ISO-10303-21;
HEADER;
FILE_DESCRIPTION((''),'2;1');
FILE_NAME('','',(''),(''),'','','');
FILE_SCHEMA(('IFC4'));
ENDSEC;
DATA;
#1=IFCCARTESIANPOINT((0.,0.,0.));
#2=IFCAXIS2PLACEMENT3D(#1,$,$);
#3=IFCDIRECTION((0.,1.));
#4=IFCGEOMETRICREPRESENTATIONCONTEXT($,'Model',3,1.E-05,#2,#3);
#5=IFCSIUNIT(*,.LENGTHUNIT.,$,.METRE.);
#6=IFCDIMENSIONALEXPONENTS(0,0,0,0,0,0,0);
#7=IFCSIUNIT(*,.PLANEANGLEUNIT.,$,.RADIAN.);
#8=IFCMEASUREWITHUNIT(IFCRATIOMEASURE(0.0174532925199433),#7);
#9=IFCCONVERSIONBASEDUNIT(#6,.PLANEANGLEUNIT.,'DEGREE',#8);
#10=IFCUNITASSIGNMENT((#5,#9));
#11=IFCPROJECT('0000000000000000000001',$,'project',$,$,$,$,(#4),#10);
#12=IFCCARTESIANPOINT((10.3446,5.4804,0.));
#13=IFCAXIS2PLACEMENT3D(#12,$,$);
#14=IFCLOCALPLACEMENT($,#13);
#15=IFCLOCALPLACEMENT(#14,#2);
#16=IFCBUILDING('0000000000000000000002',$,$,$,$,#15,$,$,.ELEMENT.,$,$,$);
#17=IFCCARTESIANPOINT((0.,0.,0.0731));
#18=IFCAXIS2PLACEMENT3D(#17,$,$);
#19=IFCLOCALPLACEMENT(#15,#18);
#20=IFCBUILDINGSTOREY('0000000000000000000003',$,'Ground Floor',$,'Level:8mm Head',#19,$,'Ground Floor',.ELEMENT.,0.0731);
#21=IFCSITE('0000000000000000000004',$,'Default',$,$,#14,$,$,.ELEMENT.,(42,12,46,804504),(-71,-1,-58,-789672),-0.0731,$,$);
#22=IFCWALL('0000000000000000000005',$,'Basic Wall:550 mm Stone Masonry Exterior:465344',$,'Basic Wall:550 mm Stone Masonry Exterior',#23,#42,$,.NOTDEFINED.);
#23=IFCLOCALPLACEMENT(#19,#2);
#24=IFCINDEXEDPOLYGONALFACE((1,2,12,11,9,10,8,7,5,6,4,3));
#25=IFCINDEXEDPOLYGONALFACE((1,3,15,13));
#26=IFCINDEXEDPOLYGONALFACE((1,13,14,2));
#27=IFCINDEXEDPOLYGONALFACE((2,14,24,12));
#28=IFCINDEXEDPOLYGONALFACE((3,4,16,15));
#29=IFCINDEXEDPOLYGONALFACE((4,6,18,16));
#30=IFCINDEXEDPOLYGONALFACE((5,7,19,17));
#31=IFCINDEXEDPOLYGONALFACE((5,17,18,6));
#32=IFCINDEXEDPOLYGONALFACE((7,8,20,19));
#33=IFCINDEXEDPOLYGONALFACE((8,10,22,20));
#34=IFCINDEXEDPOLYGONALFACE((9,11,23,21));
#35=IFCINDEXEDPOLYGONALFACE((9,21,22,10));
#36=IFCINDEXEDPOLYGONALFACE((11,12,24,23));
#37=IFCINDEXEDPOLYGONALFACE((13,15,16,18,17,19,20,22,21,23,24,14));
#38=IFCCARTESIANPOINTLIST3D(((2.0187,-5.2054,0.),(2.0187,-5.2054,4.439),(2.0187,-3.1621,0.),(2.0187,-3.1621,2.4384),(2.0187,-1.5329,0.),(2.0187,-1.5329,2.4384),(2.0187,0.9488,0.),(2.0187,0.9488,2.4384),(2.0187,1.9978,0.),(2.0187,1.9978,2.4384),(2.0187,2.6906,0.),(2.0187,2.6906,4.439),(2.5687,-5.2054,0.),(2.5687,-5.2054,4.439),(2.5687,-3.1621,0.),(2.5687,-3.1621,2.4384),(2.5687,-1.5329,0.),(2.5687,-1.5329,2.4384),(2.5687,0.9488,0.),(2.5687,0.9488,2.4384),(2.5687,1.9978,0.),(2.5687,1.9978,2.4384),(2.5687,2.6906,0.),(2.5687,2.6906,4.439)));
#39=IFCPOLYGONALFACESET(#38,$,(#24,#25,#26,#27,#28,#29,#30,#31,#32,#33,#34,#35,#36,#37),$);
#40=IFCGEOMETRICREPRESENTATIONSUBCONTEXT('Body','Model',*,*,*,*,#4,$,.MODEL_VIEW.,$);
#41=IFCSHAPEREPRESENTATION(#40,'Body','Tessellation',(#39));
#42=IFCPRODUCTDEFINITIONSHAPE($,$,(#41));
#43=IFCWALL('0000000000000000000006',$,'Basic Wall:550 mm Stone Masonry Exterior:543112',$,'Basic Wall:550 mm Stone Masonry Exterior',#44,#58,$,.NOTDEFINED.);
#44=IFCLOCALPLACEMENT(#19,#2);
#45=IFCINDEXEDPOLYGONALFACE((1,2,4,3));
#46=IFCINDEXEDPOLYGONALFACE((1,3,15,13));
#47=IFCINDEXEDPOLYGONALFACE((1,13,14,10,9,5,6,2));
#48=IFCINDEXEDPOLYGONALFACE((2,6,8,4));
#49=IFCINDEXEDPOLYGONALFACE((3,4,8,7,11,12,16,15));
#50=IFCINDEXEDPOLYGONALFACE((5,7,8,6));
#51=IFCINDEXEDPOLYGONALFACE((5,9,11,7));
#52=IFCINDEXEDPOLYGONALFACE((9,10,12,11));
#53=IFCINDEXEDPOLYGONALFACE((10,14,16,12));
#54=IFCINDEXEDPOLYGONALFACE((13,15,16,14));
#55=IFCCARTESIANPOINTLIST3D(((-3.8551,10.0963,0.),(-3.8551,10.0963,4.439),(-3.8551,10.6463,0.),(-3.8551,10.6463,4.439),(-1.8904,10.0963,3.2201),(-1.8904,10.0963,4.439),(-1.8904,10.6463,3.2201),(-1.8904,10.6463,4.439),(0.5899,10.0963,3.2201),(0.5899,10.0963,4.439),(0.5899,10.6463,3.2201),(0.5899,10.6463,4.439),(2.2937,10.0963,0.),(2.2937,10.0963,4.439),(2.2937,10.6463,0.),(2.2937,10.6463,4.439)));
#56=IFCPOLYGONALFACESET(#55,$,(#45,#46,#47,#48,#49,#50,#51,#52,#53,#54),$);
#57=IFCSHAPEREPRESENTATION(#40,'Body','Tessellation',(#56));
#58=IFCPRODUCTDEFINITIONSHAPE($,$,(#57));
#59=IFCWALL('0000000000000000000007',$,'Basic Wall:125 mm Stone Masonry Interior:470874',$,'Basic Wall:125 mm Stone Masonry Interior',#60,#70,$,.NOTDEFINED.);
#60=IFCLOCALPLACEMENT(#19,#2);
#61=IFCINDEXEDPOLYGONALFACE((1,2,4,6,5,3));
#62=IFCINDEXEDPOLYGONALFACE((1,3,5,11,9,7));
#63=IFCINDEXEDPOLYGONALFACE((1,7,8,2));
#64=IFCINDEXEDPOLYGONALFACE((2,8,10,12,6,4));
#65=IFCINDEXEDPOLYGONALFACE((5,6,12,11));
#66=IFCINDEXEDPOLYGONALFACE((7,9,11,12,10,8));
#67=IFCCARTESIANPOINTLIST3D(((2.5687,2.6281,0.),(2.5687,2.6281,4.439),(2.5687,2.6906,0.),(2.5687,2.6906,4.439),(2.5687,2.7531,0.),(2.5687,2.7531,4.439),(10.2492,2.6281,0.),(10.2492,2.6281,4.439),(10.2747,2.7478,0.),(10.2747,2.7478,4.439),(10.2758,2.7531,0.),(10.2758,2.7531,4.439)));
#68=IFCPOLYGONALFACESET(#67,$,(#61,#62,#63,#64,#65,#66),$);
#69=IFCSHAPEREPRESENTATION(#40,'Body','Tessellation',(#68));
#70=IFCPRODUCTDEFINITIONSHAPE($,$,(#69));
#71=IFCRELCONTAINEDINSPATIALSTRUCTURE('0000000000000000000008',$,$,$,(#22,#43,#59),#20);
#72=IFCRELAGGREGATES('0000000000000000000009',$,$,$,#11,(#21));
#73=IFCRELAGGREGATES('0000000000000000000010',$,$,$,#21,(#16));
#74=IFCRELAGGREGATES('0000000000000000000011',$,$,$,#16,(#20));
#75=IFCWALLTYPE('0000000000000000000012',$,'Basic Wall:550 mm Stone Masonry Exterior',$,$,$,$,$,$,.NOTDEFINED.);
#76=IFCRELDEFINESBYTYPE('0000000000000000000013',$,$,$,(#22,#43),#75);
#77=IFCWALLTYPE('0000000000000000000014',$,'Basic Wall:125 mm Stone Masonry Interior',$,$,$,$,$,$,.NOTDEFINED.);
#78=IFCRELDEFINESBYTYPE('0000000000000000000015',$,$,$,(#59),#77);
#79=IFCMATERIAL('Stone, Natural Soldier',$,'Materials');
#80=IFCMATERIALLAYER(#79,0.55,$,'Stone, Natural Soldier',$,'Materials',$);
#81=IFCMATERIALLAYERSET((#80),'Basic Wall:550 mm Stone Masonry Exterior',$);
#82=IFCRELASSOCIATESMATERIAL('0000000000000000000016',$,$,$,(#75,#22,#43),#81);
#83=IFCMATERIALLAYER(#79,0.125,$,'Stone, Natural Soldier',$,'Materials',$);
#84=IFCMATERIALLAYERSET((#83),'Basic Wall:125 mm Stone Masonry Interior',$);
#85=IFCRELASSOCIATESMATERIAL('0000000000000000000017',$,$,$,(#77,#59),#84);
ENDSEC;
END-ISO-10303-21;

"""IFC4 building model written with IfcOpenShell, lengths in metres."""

from ifc_helpers import new_model, entity, si_unit, converted_unit, direction, frame, frame_2d, origin, origin_2d_with_axis, place, context, subcontext, project, spatial, polyline, rectangle, outline, extrude, material, layer, layer_set, layer_usage, type_object, element, save


model = new_model("IFC4")

# Units and contexts
model_context = context("Model", 3, precision=1e-05, world=origin(), true_north=direction((0.0, 1.0)))
body_context = subcontext(model_context, "Body", "Model", "MODEL_VIEW")
ifc_project = project(units=[si_unit("LENGTHUNIT", "METRE"), converted_unit("PLANEANGLEUNIT", "DEGREE", entity("IfcRatioMeasure", 0.0174532925199433), si_unit("PLANEANGLEUNIT", "RADIAN"), dimensions=[0, 0, 0, 0, 0, 0, 0])], contexts=[model_context])

# Site, building, storey
site_placement = place(None, frame((10.3446, 5.4804, 0.0)))
site = spatial("IfcSite", under=ifc_project, at=site_placement, Name="Default", CompositionType="ELEMENT", RefLatitude=(42, 12, 46, 804504), RefLongitude=(-71, -1, -58, -789672), RefElevation=-0.0731)
building_placement = place(site_placement, origin())
building = spatial("IfcBuilding", under=site, at=building_placement, CompositionType="ELEMENT")
storey_placement = place(building_placement, frame((0.0, 0.0, 0.0731)))
storey = spatial("IfcBuildingStorey", under=building, at=storey_placement, Name="Ground Floor", ObjectType="Level:8mm Head", LongName="Ground Floor", CompositionType="ELEMENT", Elevation=0.0731)

# Shared definitions
ifc_material_1 = material(Name="Stone, Natural Soldier", Category="Materials")
ifc_layer_1 = layer(ifc_material_1, 0.55, Name="Stone, Natural Soldier", Category="Materials")
ifc_layer_set_1 = layer_set([ifc_layer_1], Name="Basic Wall:550 mm Stone Masonry Exterior")
wall_type_1 = type_object("IfcWallType", Name="Basic Wall:550 mm Stone Masonry Exterior", PredefinedType="NOTDEFINED", material=ifc_layer_set_1)

# Wall, openings
ifc_layer_usage_1 = layer_usage(ifc_layer_set_1, "AXIS2", "NEGATIVE", 0.275)
wall_1_placement = place(storey_placement, frame((2.2937, 2.6906, 0.0), z_axis=(0.0, 0.0, 1.0), x_axis=(0.0, -1.0, 0.0)))
wall_1 = element("IfcWall", 1, at=wall_1_placement, inside=storey, type_object=wall_type_1, material=ifc_layer_usage_1, Name="Basic Wall:550 mm Stone Masonry Exterior:465344", ObjectType="Basic Wall:550 mm Stone Masonry Exterior", PredefinedType="NOTDEFINED", context=body_context, shape_type="SweptSolid", body=[
    extrude(rectangle(XDim=7.8961, YDim=0.55, at=frame_2d((3.948, 0.0), x_axis=(-1.0, 0.0))), origin(), (0.0, 0.0, 1.0), 4.439),
])
opening_1_placement = place(wall_1_placement, frame((1.7418, -0.275, 0.0)))
element("IfcOpeningElement", 2, at=opening_1_placement, cuts=wall_1, ObjectType="Opening", PredefinedType="OPENING", context=body_context, shape_type="SweptSolid", body=[
    extrude(rectangle(XDim=2.4384, YDim=1.049, at=origin_2d_with_axis()), frame((-0.5245, 0.0, 1.2192), z_axis=(0.0, 1.0, 0.0), x_axis=(0.0, 0.0, -1.0)), (0.0, 0.0, 1.0), 0.55),
])
opening_2_placement = place(wall_1_placement, frame((5.8528, -0.275, 0.0)))
element("IfcOpeningElement", 3, at=opening_2_placement, cuts=wall_1, ObjectType="Opening", PredefinedType="OPENING", context=body_context, shape_type="SweptSolid", body=[
    extrude(rectangle(XDim=2.4384, YDim=1.6292, at=origin_2d_with_axis()), frame((-0.8146, 0.0, 1.2192), z_axis=(0.0, 1.0, 0.0), x_axis=(0.0, 0.0, -1.0)), (0.0, 0.0, 1.0), 0.55),
])

# Wall, opening
ifc_layer_usage_2 = layer_usage(ifc_layer_set_1, "AXIS2", "NEGATIVE", 0.275)
wall_2_placement = place(storey_placement, frame((2.2937, 10.3713, 0.0), z_axis=(0.0, 0.0, 1.0), x_axis=(-1.0, 0.0, 0.0)))
wall_2 = element("IfcWall", 4, at=wall_2_placement, inside=storey, type_object=wall_type_1, material=ifc_layer_usage_2, Name="Basic Wall:550 mm Stone Masonry Exterior:543112", ObjectType="Basic Wall:550 mm Stone Masonry Exterior", PredefinedType="NOTDEFINED", context=body_context, shape_type="SweptSolid", body=[
    extrude(rectangle(XDim=6.1488, YDim=0.55, at=frame_2d((3.0744, 0.0), x_axis=(-1.0, 0.0))), origin(), (0.0, 0.0, 1.0), 4.439),
])
opening_3_placement = place(wall_2_placement, frame((4.184, 0.275, 3.2201)))
element("IfcOpeningElement", 5, at=opening_3_placement, cuts=wall_2, ObjectType="Opening", PredefinedType="OPENING", context=body_context, shape_type="SweptSolid", body=[
    extrude(rectangle(XDim=1.2189, YDim=2.4803, at=origin_2d_with_axis()), frame((-1.2401, -0.55, 0.6095), z_axis=(0.0, 1.0, 0.0), x_axis=(0.0, 0.0, -1.0)), (0.0, 0.0, 1.0), 0.55),
])

# Wall
ifc_layer_2 = layer(ifc_material_1, 0.125, Name="Stone, Natural Soldier", Category="Materials")
ifc_layer_set_2 = layer_set([ifc_layer_2], Name="Basic Wall:125 mm Stone Masonry Interior")
ifc_layer_usage_3 = layer_usage(ifc_layer_set_2, "AXIS2", "NEGATIVE", 0.0625)
wall_type_2 = type_object("IfcWallType", Name="Basic Wall:125 mm Stone Masonry Interior", PredefinedType="NOTDEFINED", material=ifc_layer_set_2)
wall_3_placement = place(storey_placement, frame((2.5687, 2.6906, 0.0)))
element("IfcWall", 6, at=wall_3_placement, inside=storey, type_object=wall_type_2, material=ifc_layer_usage_3, Name="Basic Wall:125 mm Stone Masonry Interior:470874", ObjectType="Basic Wall:125 mm Stone Masonry Interior", PredefinedType="NOTDEFINED", context=body_context, shape_type="SweptSolid", body=[
    extrude(outline(polyline([(7.6806, -0.0625), (7.706, 0.0572), (7.7071, 0.0625), (0.0, 0.0625), (0.0, 0.0), (0.0, -0.0625), (7.6806, -0.0625)])), origin(), (0.0, 0.0, 1.0), 4.439),
])

save(model, "model.ifc")
